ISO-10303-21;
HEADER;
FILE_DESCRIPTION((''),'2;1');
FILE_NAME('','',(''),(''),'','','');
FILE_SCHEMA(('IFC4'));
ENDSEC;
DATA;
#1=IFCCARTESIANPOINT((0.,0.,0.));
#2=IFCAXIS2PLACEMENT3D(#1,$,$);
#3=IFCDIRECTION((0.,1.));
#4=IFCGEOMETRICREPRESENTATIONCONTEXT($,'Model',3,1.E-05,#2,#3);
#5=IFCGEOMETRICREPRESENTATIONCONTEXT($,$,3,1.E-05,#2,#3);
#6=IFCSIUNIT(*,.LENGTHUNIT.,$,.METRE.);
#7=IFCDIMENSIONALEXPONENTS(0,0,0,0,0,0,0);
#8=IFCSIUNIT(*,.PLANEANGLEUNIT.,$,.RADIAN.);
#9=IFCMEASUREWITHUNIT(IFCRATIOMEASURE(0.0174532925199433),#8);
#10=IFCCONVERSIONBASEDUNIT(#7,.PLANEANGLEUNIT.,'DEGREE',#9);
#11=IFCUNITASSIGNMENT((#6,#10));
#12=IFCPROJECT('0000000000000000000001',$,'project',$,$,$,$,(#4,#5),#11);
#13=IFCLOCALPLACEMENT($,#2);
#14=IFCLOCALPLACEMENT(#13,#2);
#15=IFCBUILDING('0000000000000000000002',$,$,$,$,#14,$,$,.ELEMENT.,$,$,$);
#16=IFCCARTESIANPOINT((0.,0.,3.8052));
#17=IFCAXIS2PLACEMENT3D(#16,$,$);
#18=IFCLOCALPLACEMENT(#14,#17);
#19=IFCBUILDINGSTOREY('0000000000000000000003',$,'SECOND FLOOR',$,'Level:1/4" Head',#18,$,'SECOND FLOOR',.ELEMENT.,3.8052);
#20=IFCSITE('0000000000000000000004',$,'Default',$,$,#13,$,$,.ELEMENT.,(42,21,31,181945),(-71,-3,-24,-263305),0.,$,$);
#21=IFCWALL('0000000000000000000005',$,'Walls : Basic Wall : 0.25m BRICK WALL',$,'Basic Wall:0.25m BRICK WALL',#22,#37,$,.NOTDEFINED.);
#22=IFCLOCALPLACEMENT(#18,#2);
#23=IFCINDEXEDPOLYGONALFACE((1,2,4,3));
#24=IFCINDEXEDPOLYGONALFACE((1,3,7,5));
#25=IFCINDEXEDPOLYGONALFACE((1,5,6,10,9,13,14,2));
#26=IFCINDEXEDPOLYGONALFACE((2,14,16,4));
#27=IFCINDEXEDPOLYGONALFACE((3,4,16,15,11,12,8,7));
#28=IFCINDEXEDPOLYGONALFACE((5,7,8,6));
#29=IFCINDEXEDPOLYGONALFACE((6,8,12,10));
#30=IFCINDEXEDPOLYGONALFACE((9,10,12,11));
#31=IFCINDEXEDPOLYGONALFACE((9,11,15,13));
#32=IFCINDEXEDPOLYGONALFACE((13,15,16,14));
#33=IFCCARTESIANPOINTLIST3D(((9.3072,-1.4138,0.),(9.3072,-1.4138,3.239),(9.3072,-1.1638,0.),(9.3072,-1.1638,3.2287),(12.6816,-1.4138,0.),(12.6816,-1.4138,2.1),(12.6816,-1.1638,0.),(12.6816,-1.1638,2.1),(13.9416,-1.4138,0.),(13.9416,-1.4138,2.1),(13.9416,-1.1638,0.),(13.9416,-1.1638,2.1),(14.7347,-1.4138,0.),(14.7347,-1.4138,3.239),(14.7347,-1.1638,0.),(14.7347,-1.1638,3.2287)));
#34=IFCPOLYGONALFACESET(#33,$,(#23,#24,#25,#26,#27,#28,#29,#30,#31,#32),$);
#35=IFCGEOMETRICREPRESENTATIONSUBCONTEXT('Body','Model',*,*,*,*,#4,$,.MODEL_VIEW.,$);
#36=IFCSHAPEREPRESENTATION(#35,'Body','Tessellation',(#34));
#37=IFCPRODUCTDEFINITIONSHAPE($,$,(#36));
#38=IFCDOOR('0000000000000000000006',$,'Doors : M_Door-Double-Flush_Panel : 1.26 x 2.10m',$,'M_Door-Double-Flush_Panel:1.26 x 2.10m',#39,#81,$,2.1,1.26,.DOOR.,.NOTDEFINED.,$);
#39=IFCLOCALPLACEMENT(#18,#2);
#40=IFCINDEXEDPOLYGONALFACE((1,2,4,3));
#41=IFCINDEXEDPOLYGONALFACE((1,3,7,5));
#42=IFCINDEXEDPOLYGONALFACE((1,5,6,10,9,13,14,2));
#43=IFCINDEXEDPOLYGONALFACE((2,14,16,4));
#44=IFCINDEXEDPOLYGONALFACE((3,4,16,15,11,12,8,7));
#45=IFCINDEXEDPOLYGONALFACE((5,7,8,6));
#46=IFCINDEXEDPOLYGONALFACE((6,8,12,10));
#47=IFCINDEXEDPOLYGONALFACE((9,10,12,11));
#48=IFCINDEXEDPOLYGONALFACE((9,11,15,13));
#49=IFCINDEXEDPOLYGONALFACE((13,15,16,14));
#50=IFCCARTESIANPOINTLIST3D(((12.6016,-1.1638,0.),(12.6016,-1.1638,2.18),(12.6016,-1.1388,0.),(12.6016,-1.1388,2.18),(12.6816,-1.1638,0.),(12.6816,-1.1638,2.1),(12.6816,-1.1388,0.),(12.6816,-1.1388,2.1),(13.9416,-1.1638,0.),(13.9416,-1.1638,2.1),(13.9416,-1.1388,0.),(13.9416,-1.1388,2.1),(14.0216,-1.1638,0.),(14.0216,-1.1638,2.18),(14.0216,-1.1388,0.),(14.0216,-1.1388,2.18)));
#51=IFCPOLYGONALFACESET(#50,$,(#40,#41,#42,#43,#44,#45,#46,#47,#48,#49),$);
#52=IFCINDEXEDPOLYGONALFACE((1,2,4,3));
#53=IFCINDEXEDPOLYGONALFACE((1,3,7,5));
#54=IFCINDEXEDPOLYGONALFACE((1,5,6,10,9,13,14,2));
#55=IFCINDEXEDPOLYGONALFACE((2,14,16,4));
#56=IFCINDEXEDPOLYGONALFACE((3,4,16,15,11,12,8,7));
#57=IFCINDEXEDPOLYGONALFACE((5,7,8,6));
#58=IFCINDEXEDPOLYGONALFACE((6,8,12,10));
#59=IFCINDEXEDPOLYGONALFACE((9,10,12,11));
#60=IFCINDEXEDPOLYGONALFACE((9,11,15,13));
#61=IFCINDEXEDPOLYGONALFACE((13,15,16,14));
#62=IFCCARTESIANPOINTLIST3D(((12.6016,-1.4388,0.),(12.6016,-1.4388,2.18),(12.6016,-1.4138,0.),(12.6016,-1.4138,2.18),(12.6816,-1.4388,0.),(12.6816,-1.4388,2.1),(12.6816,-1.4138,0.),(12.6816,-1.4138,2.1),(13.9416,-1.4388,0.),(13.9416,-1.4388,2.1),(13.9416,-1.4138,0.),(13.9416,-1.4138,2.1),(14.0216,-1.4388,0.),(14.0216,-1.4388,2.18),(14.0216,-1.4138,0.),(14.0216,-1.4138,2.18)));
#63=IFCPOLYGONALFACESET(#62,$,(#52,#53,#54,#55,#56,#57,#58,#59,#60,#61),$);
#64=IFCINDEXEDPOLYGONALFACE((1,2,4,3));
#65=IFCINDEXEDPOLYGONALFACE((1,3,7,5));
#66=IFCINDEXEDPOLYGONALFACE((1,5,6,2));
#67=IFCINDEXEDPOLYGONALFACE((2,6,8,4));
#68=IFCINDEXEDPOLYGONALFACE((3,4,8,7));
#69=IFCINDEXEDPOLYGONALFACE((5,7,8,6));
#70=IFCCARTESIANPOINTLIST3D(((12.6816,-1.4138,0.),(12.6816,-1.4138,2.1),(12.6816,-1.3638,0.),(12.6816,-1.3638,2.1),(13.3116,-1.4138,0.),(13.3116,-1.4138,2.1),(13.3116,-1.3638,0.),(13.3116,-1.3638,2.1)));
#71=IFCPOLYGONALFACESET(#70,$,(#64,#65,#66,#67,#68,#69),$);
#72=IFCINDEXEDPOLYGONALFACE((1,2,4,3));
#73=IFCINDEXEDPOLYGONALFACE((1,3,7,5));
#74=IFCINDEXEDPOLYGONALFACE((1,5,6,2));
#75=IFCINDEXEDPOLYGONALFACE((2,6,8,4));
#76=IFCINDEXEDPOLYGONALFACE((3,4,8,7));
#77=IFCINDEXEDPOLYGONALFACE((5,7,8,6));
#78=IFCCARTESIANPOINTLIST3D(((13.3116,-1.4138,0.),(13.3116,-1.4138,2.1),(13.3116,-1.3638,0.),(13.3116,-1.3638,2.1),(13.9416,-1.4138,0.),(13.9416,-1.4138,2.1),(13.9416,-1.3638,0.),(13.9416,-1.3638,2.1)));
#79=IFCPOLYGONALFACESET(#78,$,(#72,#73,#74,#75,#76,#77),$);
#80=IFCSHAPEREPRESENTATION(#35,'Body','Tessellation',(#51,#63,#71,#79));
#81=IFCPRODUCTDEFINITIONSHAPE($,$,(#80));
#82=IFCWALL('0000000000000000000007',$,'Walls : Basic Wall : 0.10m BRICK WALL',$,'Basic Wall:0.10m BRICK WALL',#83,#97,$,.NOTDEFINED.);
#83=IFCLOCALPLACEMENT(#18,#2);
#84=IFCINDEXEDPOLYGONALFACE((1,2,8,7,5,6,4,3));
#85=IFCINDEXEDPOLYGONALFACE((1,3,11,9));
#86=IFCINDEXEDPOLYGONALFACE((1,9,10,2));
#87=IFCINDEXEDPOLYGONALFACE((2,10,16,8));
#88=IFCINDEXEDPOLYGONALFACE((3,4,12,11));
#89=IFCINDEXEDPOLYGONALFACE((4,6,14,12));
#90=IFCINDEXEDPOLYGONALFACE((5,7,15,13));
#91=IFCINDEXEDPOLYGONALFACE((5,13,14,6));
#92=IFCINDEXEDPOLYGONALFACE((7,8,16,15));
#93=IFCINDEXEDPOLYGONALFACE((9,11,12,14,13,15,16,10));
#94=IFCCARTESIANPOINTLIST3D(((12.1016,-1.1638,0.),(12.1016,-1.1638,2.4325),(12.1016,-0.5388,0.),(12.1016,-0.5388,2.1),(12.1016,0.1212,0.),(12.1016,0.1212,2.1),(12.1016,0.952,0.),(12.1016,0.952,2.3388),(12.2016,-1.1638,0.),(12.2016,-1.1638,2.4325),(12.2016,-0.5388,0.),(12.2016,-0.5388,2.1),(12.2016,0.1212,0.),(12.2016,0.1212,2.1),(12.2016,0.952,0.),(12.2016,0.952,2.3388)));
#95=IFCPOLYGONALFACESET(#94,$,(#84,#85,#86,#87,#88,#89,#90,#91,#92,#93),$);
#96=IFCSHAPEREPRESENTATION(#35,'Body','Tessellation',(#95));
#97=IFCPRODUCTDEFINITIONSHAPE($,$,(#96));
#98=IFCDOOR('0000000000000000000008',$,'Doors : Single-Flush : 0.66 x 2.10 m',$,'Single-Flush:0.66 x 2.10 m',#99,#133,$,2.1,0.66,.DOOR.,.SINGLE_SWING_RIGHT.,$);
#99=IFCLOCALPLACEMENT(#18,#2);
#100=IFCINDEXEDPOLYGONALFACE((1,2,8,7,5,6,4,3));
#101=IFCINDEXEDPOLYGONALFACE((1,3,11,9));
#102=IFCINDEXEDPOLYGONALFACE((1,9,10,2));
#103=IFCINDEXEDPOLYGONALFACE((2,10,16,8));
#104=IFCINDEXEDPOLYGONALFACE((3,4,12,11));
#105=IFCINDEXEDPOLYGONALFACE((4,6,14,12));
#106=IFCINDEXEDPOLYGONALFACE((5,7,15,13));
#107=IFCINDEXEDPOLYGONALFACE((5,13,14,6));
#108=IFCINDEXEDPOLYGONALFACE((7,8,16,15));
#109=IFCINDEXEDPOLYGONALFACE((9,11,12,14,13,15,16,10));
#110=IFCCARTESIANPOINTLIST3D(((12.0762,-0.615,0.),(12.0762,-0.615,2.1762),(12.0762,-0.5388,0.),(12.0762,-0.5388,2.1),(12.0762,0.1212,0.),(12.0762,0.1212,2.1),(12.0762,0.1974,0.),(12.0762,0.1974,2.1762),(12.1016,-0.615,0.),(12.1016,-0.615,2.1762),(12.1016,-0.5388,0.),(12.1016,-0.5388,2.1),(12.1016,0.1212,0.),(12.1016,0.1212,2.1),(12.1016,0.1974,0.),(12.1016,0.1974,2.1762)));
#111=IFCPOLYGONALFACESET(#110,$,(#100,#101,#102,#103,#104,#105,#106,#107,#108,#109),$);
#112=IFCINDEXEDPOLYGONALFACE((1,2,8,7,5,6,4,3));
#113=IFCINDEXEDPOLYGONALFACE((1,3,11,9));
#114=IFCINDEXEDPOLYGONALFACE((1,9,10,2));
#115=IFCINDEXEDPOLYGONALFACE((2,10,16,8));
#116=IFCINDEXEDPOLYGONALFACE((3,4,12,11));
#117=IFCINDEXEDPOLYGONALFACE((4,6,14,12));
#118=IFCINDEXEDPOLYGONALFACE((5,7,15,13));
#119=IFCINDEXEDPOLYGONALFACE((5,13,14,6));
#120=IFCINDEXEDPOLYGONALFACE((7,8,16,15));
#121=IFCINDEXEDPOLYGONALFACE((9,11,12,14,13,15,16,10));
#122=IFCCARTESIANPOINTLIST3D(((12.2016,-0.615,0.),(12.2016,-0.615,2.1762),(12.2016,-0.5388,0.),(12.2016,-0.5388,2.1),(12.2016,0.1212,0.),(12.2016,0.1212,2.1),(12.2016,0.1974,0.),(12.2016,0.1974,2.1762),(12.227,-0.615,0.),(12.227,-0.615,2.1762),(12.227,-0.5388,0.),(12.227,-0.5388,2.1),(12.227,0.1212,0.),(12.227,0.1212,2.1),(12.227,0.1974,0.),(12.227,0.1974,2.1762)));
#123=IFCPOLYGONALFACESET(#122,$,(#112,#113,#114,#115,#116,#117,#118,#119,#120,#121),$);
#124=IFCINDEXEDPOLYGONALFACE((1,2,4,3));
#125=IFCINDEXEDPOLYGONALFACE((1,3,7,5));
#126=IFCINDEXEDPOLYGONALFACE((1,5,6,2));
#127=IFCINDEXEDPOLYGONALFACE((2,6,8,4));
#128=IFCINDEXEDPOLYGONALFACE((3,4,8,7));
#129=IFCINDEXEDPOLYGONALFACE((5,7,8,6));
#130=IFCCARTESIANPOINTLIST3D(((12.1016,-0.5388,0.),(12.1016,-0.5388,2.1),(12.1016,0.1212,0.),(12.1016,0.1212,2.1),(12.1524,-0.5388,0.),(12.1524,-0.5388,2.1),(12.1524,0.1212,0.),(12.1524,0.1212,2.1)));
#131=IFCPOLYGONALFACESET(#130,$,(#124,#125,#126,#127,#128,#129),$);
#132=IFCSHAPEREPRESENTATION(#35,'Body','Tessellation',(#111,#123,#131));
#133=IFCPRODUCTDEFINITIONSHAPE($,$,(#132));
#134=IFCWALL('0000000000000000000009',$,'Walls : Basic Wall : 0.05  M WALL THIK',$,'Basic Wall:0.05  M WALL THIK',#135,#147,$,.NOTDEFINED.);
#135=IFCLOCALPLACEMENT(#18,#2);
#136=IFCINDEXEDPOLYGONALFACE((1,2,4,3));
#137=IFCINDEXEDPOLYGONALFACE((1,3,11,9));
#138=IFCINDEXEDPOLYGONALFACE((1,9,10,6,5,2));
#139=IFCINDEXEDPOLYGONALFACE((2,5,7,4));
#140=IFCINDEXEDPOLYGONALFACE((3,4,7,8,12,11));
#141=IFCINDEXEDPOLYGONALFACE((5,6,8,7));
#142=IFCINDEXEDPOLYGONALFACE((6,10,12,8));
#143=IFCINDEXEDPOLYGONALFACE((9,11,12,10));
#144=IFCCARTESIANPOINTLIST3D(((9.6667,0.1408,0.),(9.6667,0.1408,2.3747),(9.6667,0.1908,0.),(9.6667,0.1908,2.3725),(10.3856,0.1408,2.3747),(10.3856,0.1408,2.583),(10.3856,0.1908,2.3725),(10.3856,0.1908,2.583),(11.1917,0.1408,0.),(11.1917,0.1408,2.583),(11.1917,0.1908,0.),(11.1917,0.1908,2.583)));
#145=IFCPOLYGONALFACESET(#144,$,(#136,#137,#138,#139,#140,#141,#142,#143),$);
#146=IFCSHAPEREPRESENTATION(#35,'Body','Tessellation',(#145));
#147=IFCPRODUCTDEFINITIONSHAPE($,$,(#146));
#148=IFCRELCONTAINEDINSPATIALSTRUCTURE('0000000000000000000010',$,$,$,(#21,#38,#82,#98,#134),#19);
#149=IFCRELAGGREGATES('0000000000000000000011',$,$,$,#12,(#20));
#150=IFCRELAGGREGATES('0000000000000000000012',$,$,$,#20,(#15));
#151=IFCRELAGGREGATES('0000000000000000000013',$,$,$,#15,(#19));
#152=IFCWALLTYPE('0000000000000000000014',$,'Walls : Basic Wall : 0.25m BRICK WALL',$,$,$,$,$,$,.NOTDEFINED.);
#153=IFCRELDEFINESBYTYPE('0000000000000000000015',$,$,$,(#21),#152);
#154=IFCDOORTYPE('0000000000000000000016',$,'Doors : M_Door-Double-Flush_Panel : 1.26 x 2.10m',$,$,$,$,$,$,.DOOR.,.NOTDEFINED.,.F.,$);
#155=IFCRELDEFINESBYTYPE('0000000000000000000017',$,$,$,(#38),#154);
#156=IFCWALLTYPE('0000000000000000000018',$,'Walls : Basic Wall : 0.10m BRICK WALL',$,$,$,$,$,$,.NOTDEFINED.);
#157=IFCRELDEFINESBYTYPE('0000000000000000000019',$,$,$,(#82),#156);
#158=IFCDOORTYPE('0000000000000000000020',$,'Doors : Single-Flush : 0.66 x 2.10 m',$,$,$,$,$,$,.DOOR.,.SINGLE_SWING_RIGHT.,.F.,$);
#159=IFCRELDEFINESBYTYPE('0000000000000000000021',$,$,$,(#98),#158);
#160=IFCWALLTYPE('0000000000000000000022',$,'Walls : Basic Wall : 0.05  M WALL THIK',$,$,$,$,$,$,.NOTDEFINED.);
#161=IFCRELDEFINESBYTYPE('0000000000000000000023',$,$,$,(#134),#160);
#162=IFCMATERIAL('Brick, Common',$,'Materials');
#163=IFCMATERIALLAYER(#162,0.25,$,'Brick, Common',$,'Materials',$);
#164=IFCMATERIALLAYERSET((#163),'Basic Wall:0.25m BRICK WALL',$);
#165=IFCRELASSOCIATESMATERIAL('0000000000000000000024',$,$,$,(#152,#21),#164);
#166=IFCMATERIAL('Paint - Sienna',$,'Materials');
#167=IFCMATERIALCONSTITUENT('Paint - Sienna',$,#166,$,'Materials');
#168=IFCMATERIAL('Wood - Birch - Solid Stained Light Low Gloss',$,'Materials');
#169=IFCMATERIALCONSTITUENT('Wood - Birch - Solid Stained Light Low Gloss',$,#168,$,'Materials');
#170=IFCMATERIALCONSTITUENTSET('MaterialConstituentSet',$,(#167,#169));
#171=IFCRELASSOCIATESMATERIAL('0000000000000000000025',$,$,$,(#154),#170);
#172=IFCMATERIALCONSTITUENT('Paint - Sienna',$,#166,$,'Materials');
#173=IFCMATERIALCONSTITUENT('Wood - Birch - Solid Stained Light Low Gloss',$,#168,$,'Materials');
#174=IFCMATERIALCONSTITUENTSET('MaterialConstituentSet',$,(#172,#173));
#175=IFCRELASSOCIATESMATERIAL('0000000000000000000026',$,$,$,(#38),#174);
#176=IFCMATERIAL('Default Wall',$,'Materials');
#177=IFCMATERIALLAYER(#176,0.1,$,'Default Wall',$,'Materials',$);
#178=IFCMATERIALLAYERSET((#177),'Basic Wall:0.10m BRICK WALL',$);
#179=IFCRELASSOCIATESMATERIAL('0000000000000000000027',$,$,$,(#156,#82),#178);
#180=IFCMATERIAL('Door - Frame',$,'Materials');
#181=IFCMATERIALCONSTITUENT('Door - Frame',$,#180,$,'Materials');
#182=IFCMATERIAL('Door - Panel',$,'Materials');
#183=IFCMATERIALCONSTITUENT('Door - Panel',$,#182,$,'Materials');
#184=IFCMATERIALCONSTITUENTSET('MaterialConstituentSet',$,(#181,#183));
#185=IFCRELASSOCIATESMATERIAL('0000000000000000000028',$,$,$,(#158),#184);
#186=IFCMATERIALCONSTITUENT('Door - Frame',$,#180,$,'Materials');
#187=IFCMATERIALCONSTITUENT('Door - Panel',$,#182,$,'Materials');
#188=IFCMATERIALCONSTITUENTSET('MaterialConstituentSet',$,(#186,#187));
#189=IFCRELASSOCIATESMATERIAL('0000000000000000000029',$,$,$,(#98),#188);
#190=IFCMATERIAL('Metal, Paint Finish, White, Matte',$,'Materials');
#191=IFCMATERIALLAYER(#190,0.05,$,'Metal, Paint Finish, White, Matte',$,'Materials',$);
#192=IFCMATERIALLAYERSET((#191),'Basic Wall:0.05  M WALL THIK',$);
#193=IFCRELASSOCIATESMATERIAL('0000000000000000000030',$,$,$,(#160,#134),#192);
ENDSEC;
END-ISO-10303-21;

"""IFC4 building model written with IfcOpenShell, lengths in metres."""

from ifc_helpers import new_model, entity, si_unit, converted_unit, direction, frame, frame_2d, origin, origin_2d_with_axis, place, context, subcontext, project, spatial, polyline, rectangle, outline, extrude, clip, bounded_halfspace, source, transform, mapped, material, layer, layer_set, layer_usage, constituent, constituent_set, type_object, type_shapes, element, fill, save


model = new_model("IFC4")

# Units and contexts
model_context = context("Model", 3, precision=1e-05, world=origin(), true_north=direction((0.0, 1.0)))
context_of_model = context(None, 3, precision=1e-05, world=origin(), true_north=direction((0.0, 1.0)))
body_context = subcontext(model_context, "Body", "Model", "MODEL_VIEW")
ifc_project = project(units=[si_unit("LENGTHUNIT", "METRE"), converted_unit("PLANEANGLEUNIT", "DEGREE", entity("IfcRatioMeasure", 0.0174532925199433), si_unit("PLANEANGLEUNIT", "RADIAN"), dimensions=[0, 0, 0, 0, 0, 0, 0])], contexts=[model_context, context_of_model])

# Site, building, storey
site_placement = place(None, origin())
site = spatial("IfcSite", under=ifc_project, at=site_placement, Name="Default", CompositionType="ELEMENT", RefLatitude=(42, 21, 31, 181945), RefLongitude=(-71, -3, -24, -263305), RefElevation=0.0)
building_placement = place(site_placement, origin())
building = spatial("IfcBuilding", under=site, at=building_placement, CompositionType="ELEMENT")
storey_placement = place(building_placement, frame((0.0, 0.0, 3.8052)))
storey = spatial("IfcBuildingStorey", under=building, at=storey_placement, Name="SECOND FLOOR", ObjectType="Level:1/4\" Head", LongName="SECOND FLOOR", CompositionType="ELEMENT", Elevation=3.8052)

# Shared definitions
ifc_material_1 = material(Name="Metal, Paint Finish, White, Matte", Category="Materials")

# Shared definitions
ifc_material_2 = material(Name="Door - Frame", Category="Materials")
ifc_material_3 = material(Name="Door - Panel", Category="Materials")

# Shared definitions
ifc_material_4 = material(Name="Paint - Sienna", Category="Materials")
ifc_material_5 = material(Name="Wood - Birch - Solid Stained Light Low Gloss", Category="Materials")

# Walls, openings, doors
ifc_material_6 = material(Name="Brick, Common", Category="Materials")
ifc_layer_1 = layer(ifc_material_6, 0.25, Name="Brick, Common", Category="Materials")
ifc_layer_set_1 = layer_set([ifc_layer_1], Name="Basic Wall:0.25m BRICK WALL")
ifc_layer_usage_1 = layer_usage(ifc_layer_set_1, "AXIS2", "NEGATIVE", 0.125)
wall_type_1 = type_object("IfcWallType", Name="Walls : Basic Wall : 0.25m BRICK WALL", PredefinedType="NOTDEFINED", material=ifc_layer_set_1)
wall_1_placement = place(storey_placement, frame((9.3072, -1.2888, 0.0)))
wall_1 = element("IfcWall", 1, at=wall_1_placement, inside=storey, type_object=wall_type_1, material=ifc_layer_usage_1, Name="Walls : Basic Wall : 0.25m BRICK WALL", ObjectType="Basic Wall:0.25m BRICK WALL", PredefinedType="NOTDEFINED", context=body_context, shape_type="Clipping", body=[
    clip(extrude(rectangle(XDim=5.4275, YDim=0.25, at=frame_2d((2.7137, 0.0), x_axis=(-1.0, 0.0))), origin(), (0.0, 0.0, 1.0), 3.239), bounded_halfspace(frame((0.0, -0.125, 3.239), z_axis=(0.0, -0.041435, -0.999141), x_axis=(-1.0, 0.0, 0.0)), True, frame((0.0, -0.125, 3.239)), polyline([(0.0, 0.0), (1.8297, 0.0), (1.9597, 0.0), (5.4275, 0.0), (5.4275, 0.25), (0.0, 0.25), (0.0, 0.0)]))),
])
opening_1_placement = place(wall_1_placement, frame((4.6344, 0.125, 0.0)))
opening_1 = element("IfcOpeningElement", 2, at=opening_1_placement, cuts=wall_1, ObjectType="Opening", PredefinedType="OPENING", context=body_context, shape_type="SweptSolid", body=[
    extrude(rectangle(XDim=2.1, YDim=1.26, at=frame_2d((1.05, 0.63), x_axis=(1.0, 0.0))), frame((0.0, 0.0, 0.0), z_axis=(0.0, -1.0, 0.0), x_axis=(0.0, 0.0, 1.0)), (0.0, 0.0, 1.0), 0.25),
])
ifc_constituent_1 = constituent(ifc_material_4, Name="Paint - Sienna", Category="Materials")
ifc_constituent_2 = constituent(ifc_material_5, Name="Wood - Birch - Solid Stained Light Low Gloss", Category="Materials")
ifc_constituent_set_1 = constituent_set(constituents=[ifc_constituent_1, ifc_constituent_2], Name="MaterialConstituentSet")
ifc_constituent_3 = constituent(ifc_material_4, Name="Paint - Sienna", Category="Materials")
ifc_constituent_4 = constituent(ifc_material_5, Name="Wood - Birch - Solid Stained Light Low Gloss", Category="Materials")
ifc_constituent_set_2 = constituent_set(constituents=[ifc_constituent_3, ifc_constituent_4], Name="MaterialConstituentSet")
door_type_1 = type_object("IfcDoorType", Name="Doors : M_Door-Double-Flush_Panel : 1.26 x 2.10m", OperationType="NOTDEFINED", ParameterTakesPrecedence=False, PredefinedType="DOOR", material=ifc_constituent_set_2)
shared_shape_1 = source(origin(), body_context, "Body", "SweptSolid", [
    extrude(outline(polyline([(-1.03, 0.63), (1.07, 0.63), (1.07, 0.71), (-1.11, 0.71), (-1.11, -0.71), (1.07, -0.71), (1.07, -0.63), (-1.03, -0.63), (-1.03, 0.63)])), frame((0.63, -0.025, 1.07), z_axis=(0.0, 1.0, 0.0), x_axis=(0.0, 0.0, -1.0)), (0.0, 0.0, 1.0), 0.025),
    extrude(outline(polyline([(-1.03, 0.63), (1.07, 0.63), (1.07, 0.71), (-1.11, 0.71), (-1.11, -0.71), (1.07, -0.71), (1.07, -0.63), (-1.03, -0.63), (-1.03, 0.63)])), frame((0.63, 0.25, 1.07), z_axis=(0.0, 1.0, 0.0), x_axis=(0.0, 0.0, -1.0)), (0.0, 0.0, 1.0), 0.025),
    extrude(rectangle(XDim=0.05, YDim=0.63, at=frame_2d((0.0, 0.0), x_axis=(1.0, 0.0))), frame((0.945, 0.225, 0.0), z_axis=(0.0, 0.0, 1.0), x_axis=(0.0, -1.0, 0.0)), (0.0, 0.0, 1.0), 2.1),
    extrude(rectangle(XDim=0.05, YDim=0.63, at=origin_2d_with_axis()), frame((0.315, 0.225, 0.0), z_axis=(0.0, 0.0, 1.0), x_axis=(0.0, -1.0, 0.0)), (0.0, 0.0, 1.0), 2.1),
])
type_shapes(door_type_1, [shared_shape_1])
door_1_placement = place(opening_1_placement, frame((0.0, 0.0, 0.0), z_axis=(0.0, 0.0, 1.0), x_axis=(-1.0, 0.0, 0.0)))
door_1 = element("IfcDoor", 3, at=door_1_placement, inside=storey, type_object=door_type_1, material=ifc_constituent_set_1, Name="Doors : M_Door-Double-Flush_Panel : 1.26 x 2.10m", ObjectType="M_Door-Double-Flush_Panel:1.26 x 2.10m", OperationType="NOTDEFINED", OverallHeight=2.1, OverallWidth=1.26, PredefinedType="DOOR", context=body_context, shape_type="MappedRepresentation", body=[
    mapped(shared_shape_1, transform((0.0, 0.0, 0.0), scale=1.0)),
])
fill(opening_1, door_1)
ifc_material_7 = material(Name="Default Wall", Category="Materials")
ifc_layer_2 = layer(ifc_material_7, 0.1, Name="Default Wall", Category="Materials")
ifc_layer_set_2 = layer_set([ifc_layer_2], Name="Basic Wall:0.10m BRICK WALL")
ifc_layer_usage_2 = layer_usage(ifc_layer_set_2, "AXIS2", "NEGATIVE", 0.05)
wall_type_2 = type_object("IfcWallType", Name="Walls : Basic Wall : 0.10m BRICK WALL", PredefinedType="NOTDEFINED", material=ifc_layer_set_2)
wall_2_placement = place(storey_placement, frame((12.1516, 0.952, 0.0), z_axis=(0.0, 0.0, 1.0), x_axis=(0.0, -1.0, 0.0)))
wall_2 = element("IfcWall", 4, at=wall_2_placement, inside=storey, type_object=wall_type_2, material=ifc_layer_usage_2, Name="Walls : Basic Wall : 0.10m BRICK WALL", ObjectType="Basic Wall:0.10m BRICK WALL", PredefinedType="NOTDEFINED", context=body_context, shape_type="Clipping", body=[
    clip(extrude(rectangle(XDim=2.1157, YDim=0.1, at=frame_2d((1.0579, 0.0), x_axis=(-1.0, 0.0))), origin(), (0.0, 0.0, 1.0), 2.4325), bounded_halfspace(frame((0.0, -0.05, 2.3388), z_axis=(-0.044281, 0.0, 0.999019), x_axis=(0.0, -1.0, 0.0)), False, frame((0.0, -0.05, 2.3388)), polyline([(0.0, 0.0), (2.1157, 0.0), (2.1157, 0.1), (0.0, 0.1), (0.0, 0.0)]))),
])
opening_2_placement = place(wall_2_placement, frame((1.4907, 0.05, 0.0)))
opening_2 = element("IfcOpeningElement", 5, at=opening_2_placement, cuts=wall_2, ObjectType="Opening", PredefinedType="OPENING", context=body_context, shape_type="SweptSolid", body=[
    extrude(rectangle(XDim=0.66, YDim=2.1, at=frame_2d((1.05, 0.33), x_axis=(0.0, 1.0))), frame((0.0, 0.0, 0.0), z_axis=(0.0, -1.0, 0.0), x_axis=(0.0, 0.0, 1.0)), (0.0, 0.0, 1.0), 0.1),
])
ifc_constituent_5 = constituent(ifc_material_2, Name="Door - Frame", Category="Materials")
ifc_constituent_6 = constituent(ifc_material_3, Name="Door - Panel", Category="Materials")
ifc_constituent_set_3 = constituent_set(constituents=[ifc_constituent_5, ifc_constituent_6], Name="MaterialConstituentSet")
ifc_constituent_7 = constituent(ifc_material_2, Name="Door - Frame", Category="Materials")
ifc_constituent_8 = constituent(ifc_material_3, Name="Door - Panel", Category="Materials")
ifc_constituent_set_4 = constituent_set(constituents=[ifc_constituent_7, ifc_constituent_8], Name="MaterialConstituentSet")
door_type_2 = type_object("IfcDoorType", Name="Doors : Single-Flush : 0.66 x 2.10 m", OperationType="SINGLE_SWING_RIGHT", ParameterTakesPrecedence=False, PredefinedType="DOOR", material=ifc_constituent_set_4)
shared_shape_2 = source(origin(), body_context, "Body", "SweptSolid", [
    extrude(outline(polyline([(-0.4062, -1.1072), (0.4062, -1.1072), (0.4062, 1.0691), (0.33, 1.0691), (0.33, -1.031), (-0.33, -1.031), (-0.33, 1.0691), (-0.4062, 1.0691), (-0.4062, -1.1072)])), frame((0.33, 0.1, 1.0691), z_axis=(0.0, 1.0, 0.0), x_axis=(1.0, 0.0, 0.0)), (0.0, 0.0, 1.0), 0.0254),
    extrude(outline(polyline([(-1.1072, -0.4062), (1.0691, -0.4062), (1.0691, -0.33), (-1.031, -0.33), (-1.031, 0.33), (1.0691, 0.33), (1.0691, 0.4062), (-1.1072, 0.4062), (-1.1072, -0.4062)])), frame((0.33, -0.0254, 1.0691), z_axis=(0.0, 1.0, 0.0), x_axis=(0.0, 0.0, -1.0)), (0.0, 0.0, 1.0), 0.0254),
    extrude(rectangle(XDim=0.0508, YDim=0.66, at=origin_2d_with_axis()), frame((0.33, 0.0746, 0.0), z_axis=(0.0, 0.0, 1.0), x_axis=(0.0, 1.0, 0.0)), (0.0, 0.0, 1.0), 2.1),
])
type_shapes(door_type_2, [shared_shape_2])
door_2_placement = place(opening_2_placement, frame((0.0, 0.0, 0.0), z_axis=(0.0, 0.0, 1.0), x_axis=(-1.0, 0.0, 0.0)))
door_2 = element("IfcDoor", 6, at=door_2_placement, inside=storey, type_object=door_type_2, material=ifc_constituent_set_3, Name="Doors : Single-Flush : 0.66 x 2.10 m", ObjectType="Single-Flush:0.66 x 2.10 m", OperationType="SINGLE_SWING_RIGHT", OverallHeight=2.1, OverallWidth=0.66, PredefinedType="DOOR", context=body_context, shape_type="MappedRepresentation", body=[
    mapped(shared_shape_2, transform((0.0, 0.0, 0.0), scale=1.0)),
])
fill(opening_2, door_2)

# Wall
ifc_layer_3 = layer(ifc_material_1, 0.05, Name="Metal, Paint Finish, White, Matte", Category="Materials")
ifc_layer_set_3 = layer_set([ifc_layer_3], Name="Basic Wall:0.05  M WALL THIK")
ifc_layer_usage_3 = layer_usage(ifc_layer_set_3, "AXIS2", "NEGATIVE", 0.025)
wall_type_3 = type_object("IfcWallType", Name="Walls : Basic Wall : 0.05  M WALL THIK", PredefinedType="NOTDEFINED", material=ifc_layer_set_3)
wall_3_placement = place(storey_placement, frame((11.1917, 0.1658, 0.0), z_axis=(0.0, 0.0, 1.0), x_axis=(-1.0, 0.0, 0.0)))
element("IfcWall", 7, at=wall_3_placement, inside=storey, type_object=wall_type_3, material=ifc_layer_usage_3, Name="Walls : Basic Wall : 0.05  M WALL THIK", ObjectType="Basic Wall:0.05  M WALL THIK", PredefinedType="NOTDEFINED", context=body_context, shape_type="Clipping", body=[
    clip(extrude(rectangle(XDim=1.525, YDim=0.05, at=frame_2d((0.7625, 0.0), x_axis=(-1.0, 0.0))), origin(), (0.0, 0.0, 1.0), 2.583), bounded_halfspace(frame((0.806, -0.025, 2.3725), z_axis=(0.0, -0.044281, 0.999019), x_axis=(1.0, 0.0, 0.0)), False, frame((0.806, -0.025, 2.3725)), polyline([(0.0, 0.0), (0.7189, 0.0), (0.7189, 0.05), (0.0, 0.05), (0.0, 0.0)]))),
])

save(model, "model.ifc")
